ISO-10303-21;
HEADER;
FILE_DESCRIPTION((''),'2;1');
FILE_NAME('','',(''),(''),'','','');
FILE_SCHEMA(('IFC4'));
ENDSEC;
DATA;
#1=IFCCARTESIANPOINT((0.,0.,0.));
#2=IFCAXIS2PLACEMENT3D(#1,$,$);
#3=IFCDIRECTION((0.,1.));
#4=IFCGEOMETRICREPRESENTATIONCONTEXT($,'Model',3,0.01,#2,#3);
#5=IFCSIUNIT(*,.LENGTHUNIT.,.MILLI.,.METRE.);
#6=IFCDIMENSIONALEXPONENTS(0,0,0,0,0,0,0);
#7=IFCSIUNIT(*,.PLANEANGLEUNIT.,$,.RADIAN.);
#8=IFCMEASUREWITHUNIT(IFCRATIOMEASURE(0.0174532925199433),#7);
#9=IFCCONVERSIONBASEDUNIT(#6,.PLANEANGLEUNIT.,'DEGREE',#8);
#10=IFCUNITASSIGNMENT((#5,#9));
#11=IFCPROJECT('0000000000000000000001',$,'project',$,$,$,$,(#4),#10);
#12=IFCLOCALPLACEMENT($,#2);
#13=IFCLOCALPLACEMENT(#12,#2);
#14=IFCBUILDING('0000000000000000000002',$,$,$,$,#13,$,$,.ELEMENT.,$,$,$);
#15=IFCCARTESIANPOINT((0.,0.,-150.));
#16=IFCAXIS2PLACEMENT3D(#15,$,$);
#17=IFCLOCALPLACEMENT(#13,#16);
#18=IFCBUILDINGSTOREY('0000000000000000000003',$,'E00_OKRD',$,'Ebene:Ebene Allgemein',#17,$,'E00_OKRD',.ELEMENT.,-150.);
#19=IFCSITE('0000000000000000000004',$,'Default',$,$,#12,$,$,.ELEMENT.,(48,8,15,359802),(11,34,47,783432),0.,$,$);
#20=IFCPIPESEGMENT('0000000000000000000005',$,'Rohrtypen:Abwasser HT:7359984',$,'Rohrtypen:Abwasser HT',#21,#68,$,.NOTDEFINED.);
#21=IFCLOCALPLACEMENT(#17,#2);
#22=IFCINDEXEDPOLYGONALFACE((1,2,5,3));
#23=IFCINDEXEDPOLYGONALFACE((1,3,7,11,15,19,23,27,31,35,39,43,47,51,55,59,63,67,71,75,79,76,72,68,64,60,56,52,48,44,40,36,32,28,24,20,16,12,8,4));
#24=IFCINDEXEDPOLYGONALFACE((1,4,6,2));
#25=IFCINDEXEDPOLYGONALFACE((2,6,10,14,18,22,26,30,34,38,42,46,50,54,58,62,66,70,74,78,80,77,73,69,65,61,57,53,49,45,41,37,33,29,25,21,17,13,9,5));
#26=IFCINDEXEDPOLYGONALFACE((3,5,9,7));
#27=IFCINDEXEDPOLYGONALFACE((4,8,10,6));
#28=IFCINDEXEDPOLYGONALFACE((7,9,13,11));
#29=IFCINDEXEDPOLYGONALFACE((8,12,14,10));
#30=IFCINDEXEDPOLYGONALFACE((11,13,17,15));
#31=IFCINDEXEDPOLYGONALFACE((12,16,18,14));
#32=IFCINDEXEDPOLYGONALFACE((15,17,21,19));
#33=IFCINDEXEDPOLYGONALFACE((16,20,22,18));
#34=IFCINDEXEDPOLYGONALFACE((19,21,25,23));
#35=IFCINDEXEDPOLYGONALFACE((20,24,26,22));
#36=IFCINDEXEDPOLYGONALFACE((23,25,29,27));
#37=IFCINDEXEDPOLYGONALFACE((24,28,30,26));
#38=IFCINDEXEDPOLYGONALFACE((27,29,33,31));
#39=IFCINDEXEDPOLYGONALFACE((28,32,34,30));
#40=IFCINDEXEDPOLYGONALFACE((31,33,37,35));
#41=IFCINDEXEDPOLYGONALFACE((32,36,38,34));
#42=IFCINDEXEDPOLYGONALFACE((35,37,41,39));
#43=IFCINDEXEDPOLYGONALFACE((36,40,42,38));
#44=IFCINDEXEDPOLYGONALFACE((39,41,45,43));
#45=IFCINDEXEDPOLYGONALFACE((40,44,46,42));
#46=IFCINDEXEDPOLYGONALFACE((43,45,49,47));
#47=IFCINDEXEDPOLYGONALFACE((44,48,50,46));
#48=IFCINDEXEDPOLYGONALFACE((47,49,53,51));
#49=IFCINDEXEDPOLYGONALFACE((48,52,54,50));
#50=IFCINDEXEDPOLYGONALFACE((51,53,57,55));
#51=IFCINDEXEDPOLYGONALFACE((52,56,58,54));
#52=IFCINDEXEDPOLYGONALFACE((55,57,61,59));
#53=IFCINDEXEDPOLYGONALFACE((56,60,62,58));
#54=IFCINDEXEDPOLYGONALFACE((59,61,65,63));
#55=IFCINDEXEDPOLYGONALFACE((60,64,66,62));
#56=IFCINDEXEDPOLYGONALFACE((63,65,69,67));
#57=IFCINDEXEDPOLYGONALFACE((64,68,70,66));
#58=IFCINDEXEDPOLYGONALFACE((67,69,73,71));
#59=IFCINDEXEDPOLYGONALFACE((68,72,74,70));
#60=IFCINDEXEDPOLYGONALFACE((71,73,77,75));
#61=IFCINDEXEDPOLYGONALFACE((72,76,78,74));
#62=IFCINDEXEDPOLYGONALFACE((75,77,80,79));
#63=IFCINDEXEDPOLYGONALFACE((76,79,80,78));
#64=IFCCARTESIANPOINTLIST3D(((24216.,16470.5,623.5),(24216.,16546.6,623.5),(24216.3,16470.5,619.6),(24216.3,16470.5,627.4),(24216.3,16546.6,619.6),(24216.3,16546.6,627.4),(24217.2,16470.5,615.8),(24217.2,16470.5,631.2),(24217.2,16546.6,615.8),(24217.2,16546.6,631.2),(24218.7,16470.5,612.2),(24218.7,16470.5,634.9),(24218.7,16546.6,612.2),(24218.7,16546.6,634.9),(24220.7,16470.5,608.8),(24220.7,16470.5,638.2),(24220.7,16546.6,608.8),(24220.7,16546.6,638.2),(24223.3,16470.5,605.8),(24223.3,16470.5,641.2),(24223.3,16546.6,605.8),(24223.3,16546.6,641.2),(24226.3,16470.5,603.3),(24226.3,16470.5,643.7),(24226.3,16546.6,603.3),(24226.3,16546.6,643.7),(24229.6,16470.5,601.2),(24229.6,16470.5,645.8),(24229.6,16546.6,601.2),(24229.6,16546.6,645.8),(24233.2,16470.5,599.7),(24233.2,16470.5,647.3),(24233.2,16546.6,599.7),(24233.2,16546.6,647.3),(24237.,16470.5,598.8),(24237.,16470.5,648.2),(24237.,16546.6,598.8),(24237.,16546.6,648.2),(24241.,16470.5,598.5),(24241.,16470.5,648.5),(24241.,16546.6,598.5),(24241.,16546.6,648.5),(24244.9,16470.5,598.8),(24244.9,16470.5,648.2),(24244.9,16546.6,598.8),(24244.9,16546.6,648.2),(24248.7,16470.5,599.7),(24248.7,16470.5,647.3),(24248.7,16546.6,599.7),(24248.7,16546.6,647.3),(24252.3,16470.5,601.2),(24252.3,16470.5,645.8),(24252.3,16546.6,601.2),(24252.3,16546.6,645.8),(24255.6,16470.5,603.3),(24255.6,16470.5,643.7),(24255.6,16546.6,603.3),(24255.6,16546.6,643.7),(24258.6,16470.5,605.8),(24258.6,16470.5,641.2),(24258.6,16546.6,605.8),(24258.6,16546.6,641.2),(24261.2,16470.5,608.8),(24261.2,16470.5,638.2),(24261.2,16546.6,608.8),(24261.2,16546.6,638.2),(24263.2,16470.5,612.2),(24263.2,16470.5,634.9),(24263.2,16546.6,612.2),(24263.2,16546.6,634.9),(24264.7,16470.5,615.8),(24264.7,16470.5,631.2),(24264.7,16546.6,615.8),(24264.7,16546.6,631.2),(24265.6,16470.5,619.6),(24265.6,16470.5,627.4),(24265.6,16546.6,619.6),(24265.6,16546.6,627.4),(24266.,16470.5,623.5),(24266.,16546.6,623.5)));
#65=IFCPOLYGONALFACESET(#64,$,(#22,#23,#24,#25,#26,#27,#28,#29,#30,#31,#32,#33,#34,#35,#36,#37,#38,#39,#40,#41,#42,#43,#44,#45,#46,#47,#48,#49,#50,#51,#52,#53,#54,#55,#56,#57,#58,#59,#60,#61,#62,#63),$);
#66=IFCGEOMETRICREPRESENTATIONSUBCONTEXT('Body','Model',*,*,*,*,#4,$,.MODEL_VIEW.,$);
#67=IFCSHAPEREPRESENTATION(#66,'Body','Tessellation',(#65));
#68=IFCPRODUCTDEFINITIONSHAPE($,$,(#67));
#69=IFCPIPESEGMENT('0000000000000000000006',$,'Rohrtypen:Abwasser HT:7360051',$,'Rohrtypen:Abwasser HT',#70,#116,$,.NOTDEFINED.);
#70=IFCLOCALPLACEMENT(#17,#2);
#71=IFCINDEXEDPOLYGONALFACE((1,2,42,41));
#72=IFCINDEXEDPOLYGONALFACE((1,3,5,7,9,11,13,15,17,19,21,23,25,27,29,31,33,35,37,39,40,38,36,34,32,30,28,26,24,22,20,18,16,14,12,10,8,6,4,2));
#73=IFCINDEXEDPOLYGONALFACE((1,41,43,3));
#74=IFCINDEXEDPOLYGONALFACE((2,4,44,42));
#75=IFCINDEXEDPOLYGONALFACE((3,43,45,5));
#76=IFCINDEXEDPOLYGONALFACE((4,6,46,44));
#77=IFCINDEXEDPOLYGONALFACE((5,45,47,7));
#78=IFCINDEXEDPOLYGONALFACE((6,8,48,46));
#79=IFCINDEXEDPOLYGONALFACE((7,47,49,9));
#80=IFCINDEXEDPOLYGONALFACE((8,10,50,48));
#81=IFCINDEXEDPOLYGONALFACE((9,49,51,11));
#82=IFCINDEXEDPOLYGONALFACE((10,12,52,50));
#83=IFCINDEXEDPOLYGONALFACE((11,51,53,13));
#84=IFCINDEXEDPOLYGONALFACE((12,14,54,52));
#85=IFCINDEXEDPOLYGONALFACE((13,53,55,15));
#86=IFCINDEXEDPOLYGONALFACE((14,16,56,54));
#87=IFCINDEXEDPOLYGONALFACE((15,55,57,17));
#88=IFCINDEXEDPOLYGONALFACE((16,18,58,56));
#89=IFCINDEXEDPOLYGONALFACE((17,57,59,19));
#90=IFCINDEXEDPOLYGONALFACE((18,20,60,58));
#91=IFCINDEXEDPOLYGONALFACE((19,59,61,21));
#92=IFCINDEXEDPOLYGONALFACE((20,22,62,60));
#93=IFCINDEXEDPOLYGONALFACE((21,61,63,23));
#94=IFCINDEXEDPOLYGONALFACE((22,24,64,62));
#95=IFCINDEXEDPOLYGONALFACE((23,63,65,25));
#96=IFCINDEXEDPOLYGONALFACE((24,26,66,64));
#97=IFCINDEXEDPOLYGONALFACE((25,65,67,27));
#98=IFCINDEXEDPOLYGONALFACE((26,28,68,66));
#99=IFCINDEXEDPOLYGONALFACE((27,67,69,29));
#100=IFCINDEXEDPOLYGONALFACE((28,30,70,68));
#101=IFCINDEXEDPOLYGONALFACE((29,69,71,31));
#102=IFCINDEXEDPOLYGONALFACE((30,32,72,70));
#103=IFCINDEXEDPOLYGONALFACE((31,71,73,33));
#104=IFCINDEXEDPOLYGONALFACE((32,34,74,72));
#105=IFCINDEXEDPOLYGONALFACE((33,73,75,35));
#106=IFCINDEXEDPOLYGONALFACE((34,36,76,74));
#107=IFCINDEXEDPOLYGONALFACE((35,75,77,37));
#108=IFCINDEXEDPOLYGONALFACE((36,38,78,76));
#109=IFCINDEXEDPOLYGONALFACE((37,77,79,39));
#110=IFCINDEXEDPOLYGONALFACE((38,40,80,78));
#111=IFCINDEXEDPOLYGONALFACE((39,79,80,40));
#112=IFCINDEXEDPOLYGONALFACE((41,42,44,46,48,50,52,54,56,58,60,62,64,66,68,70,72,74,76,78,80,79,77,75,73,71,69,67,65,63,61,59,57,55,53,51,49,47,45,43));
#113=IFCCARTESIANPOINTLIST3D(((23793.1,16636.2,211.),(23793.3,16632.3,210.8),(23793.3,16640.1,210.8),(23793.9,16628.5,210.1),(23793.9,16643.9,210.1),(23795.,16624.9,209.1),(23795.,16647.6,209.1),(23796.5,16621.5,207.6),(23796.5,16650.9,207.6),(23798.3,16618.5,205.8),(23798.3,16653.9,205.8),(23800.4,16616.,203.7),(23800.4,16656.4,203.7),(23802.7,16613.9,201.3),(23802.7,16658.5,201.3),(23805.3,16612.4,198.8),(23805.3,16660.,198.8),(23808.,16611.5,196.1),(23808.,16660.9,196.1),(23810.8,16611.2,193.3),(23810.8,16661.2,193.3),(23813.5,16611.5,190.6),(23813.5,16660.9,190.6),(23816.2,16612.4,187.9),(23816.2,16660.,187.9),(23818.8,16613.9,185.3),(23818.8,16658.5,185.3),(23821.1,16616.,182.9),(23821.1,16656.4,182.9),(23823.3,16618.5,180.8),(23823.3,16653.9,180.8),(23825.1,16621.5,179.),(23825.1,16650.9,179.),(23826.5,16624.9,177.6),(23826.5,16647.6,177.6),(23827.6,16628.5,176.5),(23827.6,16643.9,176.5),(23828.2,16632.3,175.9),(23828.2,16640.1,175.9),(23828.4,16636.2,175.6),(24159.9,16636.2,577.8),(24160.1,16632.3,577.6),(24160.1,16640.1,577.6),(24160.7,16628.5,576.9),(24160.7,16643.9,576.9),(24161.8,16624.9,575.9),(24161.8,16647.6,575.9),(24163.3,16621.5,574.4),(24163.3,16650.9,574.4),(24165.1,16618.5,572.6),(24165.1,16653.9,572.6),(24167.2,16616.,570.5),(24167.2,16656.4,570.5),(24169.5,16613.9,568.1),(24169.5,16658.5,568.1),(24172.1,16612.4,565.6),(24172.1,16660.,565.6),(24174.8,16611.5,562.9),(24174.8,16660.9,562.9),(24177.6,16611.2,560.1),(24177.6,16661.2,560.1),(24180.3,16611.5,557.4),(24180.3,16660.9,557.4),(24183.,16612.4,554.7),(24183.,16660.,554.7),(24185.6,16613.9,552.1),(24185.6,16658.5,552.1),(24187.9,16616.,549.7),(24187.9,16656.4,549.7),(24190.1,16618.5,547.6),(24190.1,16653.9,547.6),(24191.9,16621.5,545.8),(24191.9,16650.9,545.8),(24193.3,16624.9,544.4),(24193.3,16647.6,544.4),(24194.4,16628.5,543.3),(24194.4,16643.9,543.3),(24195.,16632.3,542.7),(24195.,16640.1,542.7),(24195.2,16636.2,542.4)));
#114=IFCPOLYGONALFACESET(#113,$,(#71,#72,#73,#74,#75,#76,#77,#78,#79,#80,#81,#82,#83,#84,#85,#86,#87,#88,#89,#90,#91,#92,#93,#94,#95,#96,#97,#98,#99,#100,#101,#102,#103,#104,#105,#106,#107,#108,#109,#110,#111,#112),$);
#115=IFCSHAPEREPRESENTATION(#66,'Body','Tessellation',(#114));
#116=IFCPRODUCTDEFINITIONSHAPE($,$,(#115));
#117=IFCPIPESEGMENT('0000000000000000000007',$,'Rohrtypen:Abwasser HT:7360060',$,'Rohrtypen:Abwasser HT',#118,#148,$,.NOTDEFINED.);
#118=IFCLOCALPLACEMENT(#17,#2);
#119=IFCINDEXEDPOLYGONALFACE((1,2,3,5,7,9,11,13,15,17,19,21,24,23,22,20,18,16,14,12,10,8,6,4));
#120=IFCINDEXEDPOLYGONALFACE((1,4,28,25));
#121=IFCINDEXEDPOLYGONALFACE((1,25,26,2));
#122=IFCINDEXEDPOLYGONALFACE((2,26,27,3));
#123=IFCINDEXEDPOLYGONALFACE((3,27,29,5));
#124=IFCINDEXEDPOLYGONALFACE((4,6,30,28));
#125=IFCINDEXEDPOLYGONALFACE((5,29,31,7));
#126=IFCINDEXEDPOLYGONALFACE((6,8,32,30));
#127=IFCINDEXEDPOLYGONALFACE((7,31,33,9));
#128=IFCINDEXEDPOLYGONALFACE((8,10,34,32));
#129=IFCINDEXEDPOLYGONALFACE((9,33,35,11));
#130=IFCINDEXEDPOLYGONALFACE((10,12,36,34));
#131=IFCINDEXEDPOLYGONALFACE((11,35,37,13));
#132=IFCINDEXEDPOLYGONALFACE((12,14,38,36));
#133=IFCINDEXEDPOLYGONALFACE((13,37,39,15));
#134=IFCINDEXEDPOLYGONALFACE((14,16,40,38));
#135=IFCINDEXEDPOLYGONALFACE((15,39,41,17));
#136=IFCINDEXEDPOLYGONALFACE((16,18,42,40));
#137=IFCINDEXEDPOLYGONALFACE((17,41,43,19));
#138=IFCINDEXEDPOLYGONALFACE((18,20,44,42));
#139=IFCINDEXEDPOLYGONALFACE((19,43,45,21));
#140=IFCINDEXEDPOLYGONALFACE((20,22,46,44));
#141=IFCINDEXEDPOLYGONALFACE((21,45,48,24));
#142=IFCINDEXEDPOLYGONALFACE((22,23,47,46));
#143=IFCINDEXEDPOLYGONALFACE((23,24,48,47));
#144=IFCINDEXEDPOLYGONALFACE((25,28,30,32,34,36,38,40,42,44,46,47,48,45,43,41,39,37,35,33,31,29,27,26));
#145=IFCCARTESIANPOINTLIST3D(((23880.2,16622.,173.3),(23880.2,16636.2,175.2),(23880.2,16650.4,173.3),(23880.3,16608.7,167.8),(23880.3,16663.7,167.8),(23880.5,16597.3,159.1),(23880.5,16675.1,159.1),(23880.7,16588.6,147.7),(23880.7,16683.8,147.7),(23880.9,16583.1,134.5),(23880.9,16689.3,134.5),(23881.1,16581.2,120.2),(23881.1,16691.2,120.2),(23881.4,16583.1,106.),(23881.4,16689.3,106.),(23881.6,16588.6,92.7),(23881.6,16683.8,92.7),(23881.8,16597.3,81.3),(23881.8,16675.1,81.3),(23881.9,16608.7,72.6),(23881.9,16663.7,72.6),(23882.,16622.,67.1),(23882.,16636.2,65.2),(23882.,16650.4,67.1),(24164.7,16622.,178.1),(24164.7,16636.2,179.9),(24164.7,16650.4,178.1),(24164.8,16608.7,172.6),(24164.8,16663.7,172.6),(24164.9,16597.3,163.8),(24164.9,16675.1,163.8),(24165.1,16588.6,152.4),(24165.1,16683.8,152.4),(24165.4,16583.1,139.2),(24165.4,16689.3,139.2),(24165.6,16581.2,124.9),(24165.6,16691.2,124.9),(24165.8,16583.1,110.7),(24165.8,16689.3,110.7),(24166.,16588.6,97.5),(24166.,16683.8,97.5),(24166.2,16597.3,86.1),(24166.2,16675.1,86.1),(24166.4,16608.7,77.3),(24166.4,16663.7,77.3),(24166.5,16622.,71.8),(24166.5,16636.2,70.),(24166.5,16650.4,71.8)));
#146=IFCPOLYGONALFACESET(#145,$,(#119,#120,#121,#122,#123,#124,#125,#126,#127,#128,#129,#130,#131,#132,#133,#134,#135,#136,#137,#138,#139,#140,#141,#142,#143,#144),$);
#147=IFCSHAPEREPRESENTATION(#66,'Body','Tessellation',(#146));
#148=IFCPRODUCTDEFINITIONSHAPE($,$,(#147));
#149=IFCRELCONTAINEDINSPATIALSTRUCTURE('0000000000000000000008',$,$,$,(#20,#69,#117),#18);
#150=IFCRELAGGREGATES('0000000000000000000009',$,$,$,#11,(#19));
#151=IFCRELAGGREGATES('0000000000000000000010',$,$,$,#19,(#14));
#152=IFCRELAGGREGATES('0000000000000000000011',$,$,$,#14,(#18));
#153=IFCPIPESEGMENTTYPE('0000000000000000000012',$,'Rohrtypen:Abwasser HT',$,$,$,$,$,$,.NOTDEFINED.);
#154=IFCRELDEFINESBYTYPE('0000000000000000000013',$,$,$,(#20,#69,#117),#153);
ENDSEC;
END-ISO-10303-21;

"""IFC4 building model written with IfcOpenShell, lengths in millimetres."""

from ifc_helpers import new_model, entity, si_unit, converted_unit, direction, frame, origin, place, context, subcontext, project, spatial, indexed_curve, outline, extrude, type_object, element, save


model = new_model("IFC4")

# Units and contexts
model_context = context("Model", 3, precision=0.01, world=origin(), true_north=direction((0.0, 1.0)))
body_context = subcontext(model_context, "Body", "Model", "MODEL_VIEW")
ifc_project = project(units=[si_unit("LENGTHUNIT", "METRE", prefix="MILLI"), converted_unit("PLANEANGLEUNIT", "DEGREE", entity("IfcRatioMeasure", 0.0174532925199433), si_unit("PLANEANGLEUNIT", "RADIAN"), dimensions=[0, 0, 0, 0, 0, 0, 0])], contexts=[model_context])

# Site, building, storey
site_placement = place(None, origin())
site = spatial("IfcSite", under=ifc_project, at=site_placement, Name="Default", CompositionType="ELEMENT", RefLatitude=(48, 8, 15, 359802), RefLongitude=(11, 34, 47, 783432), RefElevation=0.0)
building_placement = place(site_placement, origin())
building = spatial("IfcBuilding", under=site, at=building_placement, CompositionType="ELEMENT")
storey_placement = place(building_placement, frame((0.0, 0.0, -150.0)))
storey = spatial("IfcBuildingStorey", under=building, at=storey_placement, Name="E00_OKRD", ObjectType="Ebene:Ebene Allgemein", LongName="E00_OKRD", CompositionType="ELEMENT", Elevation=-150.0)

# Pipe segments
pipe_segment_type_1 = type_object("IfcPipeSegmentType", Name="Rohrtypen:Abwasser HT", PredefinedType="NOTDEFINED")
pipe_segment_1_placement = place(storey_placement, origin())
element("IfcPipeSegment", 1, at=pipe_segment_1_placement, inside=storey, type_object=pipe_segment_type_1, Name="Rohrtypen:Abwasser HT:7359984", ObjectType="Rohrtypen:Abwasser HT", PredefinedType="NOTDEFINED", context=body_context, shape_type="SweptSolid", body=[
    extrude(outline(indexed_curve([(25.0, 0.0), (24.7, 3.9), (23.8, 7.7), (22.3, 11.3), (20.2, 14.7), (17.7, 17.7), (14.7, 20.2), (11.3, 22.3), (7.7, 23.8), (3.9, 24.7), (0.0, 25.0), (-3.9, 24.7), (-7.7, 23.8), (-11.3, 22.3), (-14.7, 20.2), (-17.7, 17.7), (-20.2, 14.7), (-22.3, 11.3), (-23.8, 7.7), (-24.7, 3.9), (-25.0, 0.0), (-24.7, -3.9), (-23.8, -7.7), (-22.3, -11.3), (-20.2, -14.7), (-17.7, -17.7), (-14.7, -20.2), (-11.3, -22.3), (-7.7, -23.8), (-3.9, -24.7), (0.0, -25.0), (3.9, -24.7), (7.7, -23.8), (11.3, -22.3), (14.7, -20.2), (17.7, -17.7), (20.2, -14.7), (22.3, -11.3), (23.8, -7.7), (24.7, -3.9), (25.0, 0.0)], self_intersect=False)), frame((24241.0, 16470.5, 623.5), z_axis=(0.0, 1.0, 0.0), x_axis=(1.0, 0.0, 0.0)), (0.0, 0.0, 1.0), 76.0),
])
pipe_segment_2_placement = place(storey_placement, origin())
element("IfcPipeSegment", 2, at=pipe_segment_2_placement, inside=storey, type_object=pipe_segment_type_1, Name="Rohrtypen:Abwasser HT:7360051", ObjectType="Rohrtypen:Abwasser HT", PredefinedType="NOTDEFINED", context=body_context, shape_type="SweptSolid", body=[
    extrude(outline(indexed_curve([(25.0, 0.0), (24.7, 3.9), (23.8, 7.7), (22.3, 11.3), (20.2, 14.7), (17.7, 17.7), (14.7, 20.2), (11.3, 22.3), (7.7, 23.8), (3.9, 24.7), (0.0, 25.0), (-3.9, 24.7), (-7.7, 23.8), (-11.3, 22.3), (-14.7, 20.2), (-17.7, 17.7), (-20.2, 14.7), (-22.3, 11.3), (-23.8, 7.7), (-24.7, 3.9), (-25.0, 0.0), (-24.7, -3.9), (-23.8, -7.7), (-22.3, -11.3), (-20.2, -14.7), (-17.7, -17.7), (-14.7, -20.2), (-11.3, -22.3), (-7.7, -23.8), (-3.9, -24.7), (0.0, -25.0), (3.9, -24.7), (7.7, -23.8), (11.3, -22.3), (14.7, -20.2), (17.7, -17.7), (20.2, -14.7), (22.3, -11.3), (23.8, -7.7), (24.7, -3.9), (25.0, 0.0)], self_intersect=False)), frame((23810.8, 16636.2, 193.3), z_axis=(0.707107, 0.0, 0.707107), x_axis=(0.0, -1.0, 0.0)), (0.0, 0.0, 1.0), 518.7),
])
pipe_segment_3_placement = place(storey_placement, origin())
element("IfcPipeSegment", 3, at=pipe_segment_3_placement, inside=storey, type_object=pipe_segment_type_1, Name="Rohrtypen:Abwasser HT:7360060", ObjectType="Rohrtypen:Abwasser HT", PredefinedType="NOTDEFINED", context=body_context, shape_type="SweptSolid", body=[
    extrude(outline(indexed_curve([(-7.2, -54.5), (7.2, -54.5), (21.0, -50.8), (33.5, -43.6), (43.6, -33.5), (50.8, -21.0), (54.5, -7.2), (54.5, 7.2), (50.8, 21.0), (43.6, 33.5), (33.5, 43.6), (21.0, 50.8), (7.2, 54.5), (-7.2, 54.5), (-21.0, 50.8), (-33.5, 43.6), (-43.6, 33.5), (-50.8, 21.0), (-54.5, 7.2), (-54.5, -7.2), (-50.8, -21.0), (-43.6, -33.5), (-33.5, -43.6), (-21.0, -50.8), (-7.2, -54.5)], self_intersect=False)), frame((23881.1, 16636.2, 120.2), z_axis=(0.999862, 0.0, 0.016604), x_axis=(-0.016462, -0.130526, 0.991308)), (0.0, 0.0, 1.0), 284.5),
])

save(model, "model.ifc")
